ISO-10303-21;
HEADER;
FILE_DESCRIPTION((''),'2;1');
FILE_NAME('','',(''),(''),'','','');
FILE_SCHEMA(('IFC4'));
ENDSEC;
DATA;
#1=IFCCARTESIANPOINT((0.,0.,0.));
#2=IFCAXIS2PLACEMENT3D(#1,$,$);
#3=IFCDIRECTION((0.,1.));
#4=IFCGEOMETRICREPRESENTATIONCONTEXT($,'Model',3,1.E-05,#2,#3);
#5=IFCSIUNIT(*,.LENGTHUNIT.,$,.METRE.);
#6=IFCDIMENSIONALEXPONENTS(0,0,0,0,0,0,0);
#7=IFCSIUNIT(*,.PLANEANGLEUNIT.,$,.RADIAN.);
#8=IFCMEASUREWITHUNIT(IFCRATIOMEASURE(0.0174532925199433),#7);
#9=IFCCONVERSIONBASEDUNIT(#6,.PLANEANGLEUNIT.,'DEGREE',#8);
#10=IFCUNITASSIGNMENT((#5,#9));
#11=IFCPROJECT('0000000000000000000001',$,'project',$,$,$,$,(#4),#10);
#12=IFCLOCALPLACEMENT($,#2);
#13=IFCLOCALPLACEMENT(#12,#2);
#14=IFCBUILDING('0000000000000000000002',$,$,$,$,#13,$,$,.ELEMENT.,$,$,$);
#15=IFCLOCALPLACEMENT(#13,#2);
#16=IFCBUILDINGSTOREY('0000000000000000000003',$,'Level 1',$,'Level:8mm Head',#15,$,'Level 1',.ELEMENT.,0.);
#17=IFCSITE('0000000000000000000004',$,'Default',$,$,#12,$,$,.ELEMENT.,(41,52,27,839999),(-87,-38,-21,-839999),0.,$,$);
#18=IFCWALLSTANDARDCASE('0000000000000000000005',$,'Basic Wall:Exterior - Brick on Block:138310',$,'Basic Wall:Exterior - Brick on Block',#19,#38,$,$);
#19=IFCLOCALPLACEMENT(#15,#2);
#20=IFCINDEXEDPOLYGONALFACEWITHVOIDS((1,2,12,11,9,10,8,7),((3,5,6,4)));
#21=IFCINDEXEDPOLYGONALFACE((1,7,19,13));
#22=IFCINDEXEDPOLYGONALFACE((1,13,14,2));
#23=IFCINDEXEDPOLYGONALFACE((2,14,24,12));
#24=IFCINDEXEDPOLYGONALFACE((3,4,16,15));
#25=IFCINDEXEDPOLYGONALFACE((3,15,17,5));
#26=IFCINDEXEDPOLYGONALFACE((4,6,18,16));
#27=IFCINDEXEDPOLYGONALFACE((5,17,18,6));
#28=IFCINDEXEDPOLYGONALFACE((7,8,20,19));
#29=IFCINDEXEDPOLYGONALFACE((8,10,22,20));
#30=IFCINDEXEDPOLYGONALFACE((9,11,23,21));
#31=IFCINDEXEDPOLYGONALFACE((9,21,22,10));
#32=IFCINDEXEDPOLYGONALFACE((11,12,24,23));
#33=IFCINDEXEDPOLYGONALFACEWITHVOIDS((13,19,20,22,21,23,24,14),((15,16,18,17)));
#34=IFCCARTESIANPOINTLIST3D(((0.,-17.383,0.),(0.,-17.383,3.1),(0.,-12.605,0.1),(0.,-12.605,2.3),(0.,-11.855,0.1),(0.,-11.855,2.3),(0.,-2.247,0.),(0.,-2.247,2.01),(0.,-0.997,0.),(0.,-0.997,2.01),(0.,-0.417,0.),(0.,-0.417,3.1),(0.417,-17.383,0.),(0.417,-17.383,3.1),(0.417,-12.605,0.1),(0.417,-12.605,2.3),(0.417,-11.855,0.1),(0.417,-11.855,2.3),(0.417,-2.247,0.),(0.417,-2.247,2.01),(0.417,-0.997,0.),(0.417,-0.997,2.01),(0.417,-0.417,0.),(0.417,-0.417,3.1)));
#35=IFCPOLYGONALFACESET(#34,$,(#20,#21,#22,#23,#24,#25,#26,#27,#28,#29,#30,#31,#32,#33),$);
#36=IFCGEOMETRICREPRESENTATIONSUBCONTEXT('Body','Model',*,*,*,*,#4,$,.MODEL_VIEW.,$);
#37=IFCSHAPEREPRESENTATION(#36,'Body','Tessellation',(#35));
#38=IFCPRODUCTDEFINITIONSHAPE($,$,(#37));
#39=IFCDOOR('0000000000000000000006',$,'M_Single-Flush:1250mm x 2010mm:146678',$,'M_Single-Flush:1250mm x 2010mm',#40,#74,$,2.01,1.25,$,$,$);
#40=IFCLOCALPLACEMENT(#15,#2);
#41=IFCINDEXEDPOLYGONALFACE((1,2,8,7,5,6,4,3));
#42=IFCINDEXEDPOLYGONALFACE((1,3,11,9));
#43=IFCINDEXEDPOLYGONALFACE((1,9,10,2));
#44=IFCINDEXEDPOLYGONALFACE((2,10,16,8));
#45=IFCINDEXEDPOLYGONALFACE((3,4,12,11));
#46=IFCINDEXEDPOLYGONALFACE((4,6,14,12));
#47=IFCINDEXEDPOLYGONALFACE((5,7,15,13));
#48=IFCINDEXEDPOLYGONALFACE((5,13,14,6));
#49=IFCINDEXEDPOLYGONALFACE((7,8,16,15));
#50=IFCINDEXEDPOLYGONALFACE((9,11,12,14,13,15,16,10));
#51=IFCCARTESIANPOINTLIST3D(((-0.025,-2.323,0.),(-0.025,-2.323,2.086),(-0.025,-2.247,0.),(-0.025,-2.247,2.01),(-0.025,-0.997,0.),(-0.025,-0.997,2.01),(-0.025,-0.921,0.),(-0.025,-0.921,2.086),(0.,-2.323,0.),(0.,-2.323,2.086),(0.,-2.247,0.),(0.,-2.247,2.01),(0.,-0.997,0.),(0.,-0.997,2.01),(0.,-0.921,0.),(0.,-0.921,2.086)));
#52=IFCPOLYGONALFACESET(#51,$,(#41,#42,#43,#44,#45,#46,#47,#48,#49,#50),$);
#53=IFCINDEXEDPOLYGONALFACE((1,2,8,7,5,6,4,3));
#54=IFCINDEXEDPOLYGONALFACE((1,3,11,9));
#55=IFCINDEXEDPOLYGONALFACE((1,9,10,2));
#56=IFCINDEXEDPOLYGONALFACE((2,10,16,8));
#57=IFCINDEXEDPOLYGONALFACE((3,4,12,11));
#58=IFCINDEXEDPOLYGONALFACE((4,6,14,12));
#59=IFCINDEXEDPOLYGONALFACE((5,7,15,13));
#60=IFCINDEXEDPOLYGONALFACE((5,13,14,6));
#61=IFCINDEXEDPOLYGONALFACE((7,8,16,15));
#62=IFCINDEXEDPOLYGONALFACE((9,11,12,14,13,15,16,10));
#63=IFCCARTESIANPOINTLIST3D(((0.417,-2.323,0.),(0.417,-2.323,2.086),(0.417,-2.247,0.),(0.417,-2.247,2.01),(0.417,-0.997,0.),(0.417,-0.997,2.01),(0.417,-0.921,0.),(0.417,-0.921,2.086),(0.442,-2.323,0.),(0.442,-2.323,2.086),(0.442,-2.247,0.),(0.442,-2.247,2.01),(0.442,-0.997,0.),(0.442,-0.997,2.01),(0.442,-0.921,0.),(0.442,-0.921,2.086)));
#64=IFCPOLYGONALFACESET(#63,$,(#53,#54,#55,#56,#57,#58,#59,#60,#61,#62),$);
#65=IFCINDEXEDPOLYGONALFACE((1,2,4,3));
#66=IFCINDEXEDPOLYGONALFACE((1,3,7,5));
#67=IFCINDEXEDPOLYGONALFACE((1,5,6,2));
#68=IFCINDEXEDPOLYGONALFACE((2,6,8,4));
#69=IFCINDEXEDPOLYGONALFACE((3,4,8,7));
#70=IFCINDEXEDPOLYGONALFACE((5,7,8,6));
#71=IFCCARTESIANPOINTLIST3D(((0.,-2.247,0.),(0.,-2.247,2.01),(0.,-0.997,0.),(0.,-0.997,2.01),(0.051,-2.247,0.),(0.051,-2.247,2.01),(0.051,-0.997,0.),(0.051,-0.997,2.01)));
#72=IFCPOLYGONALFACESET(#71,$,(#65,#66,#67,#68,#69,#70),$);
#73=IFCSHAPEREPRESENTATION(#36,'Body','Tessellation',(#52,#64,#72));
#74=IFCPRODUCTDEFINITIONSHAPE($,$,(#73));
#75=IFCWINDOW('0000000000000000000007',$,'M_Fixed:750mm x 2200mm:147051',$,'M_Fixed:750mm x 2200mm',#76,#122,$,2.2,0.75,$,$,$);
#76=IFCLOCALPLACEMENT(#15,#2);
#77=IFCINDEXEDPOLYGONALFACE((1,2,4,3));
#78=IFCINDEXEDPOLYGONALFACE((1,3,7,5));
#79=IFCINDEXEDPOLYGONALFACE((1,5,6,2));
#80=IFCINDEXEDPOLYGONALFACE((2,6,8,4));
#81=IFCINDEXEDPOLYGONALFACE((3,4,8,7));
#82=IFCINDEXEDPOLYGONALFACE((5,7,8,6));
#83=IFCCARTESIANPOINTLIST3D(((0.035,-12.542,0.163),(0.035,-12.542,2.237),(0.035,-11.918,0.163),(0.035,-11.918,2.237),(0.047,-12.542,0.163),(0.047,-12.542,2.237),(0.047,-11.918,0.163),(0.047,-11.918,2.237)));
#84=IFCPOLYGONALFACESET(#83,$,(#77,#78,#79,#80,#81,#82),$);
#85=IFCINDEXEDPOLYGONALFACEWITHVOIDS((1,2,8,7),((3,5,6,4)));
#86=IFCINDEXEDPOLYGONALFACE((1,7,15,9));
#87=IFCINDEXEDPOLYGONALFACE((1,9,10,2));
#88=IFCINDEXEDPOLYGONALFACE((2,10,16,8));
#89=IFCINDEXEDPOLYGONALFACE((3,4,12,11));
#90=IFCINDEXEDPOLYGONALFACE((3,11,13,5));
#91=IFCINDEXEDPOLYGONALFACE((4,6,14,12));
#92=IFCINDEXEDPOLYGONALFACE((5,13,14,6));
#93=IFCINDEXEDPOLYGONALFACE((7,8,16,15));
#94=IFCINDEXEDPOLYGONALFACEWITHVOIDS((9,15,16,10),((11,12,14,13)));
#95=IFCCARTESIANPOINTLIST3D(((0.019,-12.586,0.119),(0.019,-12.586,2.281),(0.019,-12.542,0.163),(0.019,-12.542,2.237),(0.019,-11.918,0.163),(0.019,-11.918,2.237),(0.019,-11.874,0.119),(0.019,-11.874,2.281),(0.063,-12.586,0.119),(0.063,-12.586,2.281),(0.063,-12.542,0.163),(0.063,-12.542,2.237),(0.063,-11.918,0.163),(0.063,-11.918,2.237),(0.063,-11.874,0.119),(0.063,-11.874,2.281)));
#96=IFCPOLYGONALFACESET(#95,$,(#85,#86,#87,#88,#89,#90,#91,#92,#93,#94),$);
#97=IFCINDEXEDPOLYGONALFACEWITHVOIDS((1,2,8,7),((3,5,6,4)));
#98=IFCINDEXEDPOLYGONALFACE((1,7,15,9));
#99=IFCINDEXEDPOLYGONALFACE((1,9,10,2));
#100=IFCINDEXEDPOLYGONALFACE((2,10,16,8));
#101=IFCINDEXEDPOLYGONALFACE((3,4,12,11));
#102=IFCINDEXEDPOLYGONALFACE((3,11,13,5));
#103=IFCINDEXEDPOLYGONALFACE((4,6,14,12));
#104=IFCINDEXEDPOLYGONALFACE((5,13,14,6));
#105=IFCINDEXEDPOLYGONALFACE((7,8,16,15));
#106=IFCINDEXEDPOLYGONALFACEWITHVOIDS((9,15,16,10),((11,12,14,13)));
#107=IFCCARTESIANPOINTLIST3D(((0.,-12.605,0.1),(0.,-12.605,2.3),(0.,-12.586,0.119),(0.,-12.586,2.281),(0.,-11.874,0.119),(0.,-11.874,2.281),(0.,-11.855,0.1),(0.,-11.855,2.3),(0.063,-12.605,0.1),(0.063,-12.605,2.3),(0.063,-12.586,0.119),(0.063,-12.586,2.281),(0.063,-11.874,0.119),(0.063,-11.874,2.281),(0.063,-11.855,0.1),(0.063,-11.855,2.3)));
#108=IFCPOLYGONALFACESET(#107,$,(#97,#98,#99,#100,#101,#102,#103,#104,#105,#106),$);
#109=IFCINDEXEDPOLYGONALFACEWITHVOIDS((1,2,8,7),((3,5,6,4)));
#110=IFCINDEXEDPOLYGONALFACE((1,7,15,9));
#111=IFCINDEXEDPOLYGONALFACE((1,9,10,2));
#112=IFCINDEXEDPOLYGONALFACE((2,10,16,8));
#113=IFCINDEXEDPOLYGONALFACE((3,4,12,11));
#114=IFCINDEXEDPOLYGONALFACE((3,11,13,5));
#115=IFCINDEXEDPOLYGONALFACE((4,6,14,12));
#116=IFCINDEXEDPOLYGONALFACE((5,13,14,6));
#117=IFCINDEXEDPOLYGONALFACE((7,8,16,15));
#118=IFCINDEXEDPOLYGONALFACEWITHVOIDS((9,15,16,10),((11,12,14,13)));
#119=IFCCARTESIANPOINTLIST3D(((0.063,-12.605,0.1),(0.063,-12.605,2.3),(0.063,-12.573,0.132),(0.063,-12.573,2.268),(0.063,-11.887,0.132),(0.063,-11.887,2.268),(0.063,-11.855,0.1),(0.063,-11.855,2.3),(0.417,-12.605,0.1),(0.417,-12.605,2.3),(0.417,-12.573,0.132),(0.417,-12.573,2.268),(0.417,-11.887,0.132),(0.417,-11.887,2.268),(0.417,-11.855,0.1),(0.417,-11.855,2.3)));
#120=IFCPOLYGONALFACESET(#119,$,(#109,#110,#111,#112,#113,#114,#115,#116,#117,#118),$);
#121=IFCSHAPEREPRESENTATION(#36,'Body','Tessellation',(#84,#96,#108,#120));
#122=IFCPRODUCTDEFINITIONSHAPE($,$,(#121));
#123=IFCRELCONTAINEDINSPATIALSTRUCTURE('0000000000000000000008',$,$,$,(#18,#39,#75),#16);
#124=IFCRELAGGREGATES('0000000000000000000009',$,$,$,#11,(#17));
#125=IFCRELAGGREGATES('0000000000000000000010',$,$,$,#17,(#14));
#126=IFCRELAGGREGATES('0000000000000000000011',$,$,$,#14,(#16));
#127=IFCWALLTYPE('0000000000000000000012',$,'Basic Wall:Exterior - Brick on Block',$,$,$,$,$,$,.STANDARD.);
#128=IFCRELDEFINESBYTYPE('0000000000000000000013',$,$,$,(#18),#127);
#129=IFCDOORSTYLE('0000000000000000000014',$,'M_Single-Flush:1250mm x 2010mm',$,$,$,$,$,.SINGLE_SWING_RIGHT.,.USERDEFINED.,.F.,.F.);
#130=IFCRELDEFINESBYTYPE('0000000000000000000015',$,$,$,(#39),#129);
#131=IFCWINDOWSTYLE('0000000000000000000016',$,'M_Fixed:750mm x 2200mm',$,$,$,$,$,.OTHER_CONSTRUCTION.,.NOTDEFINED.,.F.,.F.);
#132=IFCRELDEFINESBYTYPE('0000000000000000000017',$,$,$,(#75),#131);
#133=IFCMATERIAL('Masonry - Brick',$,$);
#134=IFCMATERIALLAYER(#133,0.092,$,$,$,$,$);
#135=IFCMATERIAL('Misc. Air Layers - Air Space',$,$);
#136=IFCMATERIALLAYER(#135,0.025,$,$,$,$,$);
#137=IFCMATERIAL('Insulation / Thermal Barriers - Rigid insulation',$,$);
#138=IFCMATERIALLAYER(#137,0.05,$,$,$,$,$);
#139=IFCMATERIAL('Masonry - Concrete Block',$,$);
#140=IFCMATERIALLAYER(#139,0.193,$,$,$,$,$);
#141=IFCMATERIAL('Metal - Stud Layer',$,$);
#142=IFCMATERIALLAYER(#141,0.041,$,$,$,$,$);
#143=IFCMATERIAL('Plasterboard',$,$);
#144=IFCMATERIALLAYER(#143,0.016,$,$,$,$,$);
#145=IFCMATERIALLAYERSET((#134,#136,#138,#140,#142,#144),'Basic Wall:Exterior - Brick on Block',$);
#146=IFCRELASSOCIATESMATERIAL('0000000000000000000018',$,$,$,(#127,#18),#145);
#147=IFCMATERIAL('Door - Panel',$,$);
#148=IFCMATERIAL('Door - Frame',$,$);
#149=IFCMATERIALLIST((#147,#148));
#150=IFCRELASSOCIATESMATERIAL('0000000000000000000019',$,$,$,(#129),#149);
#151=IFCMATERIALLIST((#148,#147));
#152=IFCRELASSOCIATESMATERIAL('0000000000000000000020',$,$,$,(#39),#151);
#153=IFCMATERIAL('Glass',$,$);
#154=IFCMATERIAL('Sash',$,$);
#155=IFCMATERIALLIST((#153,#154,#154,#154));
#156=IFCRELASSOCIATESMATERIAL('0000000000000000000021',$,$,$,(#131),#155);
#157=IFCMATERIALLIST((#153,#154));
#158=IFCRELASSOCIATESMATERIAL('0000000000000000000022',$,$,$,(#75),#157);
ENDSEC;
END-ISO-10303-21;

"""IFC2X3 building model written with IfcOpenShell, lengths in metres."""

from ifc_helpers import new_model, entity, si_unit, converted_unit, direction, frame, frame_2d, origin, origin_2d_with_axis, place, context, subcontext, project, spatial, polyline, rectangle, outline, extrude, source, transform, mapped, material, material_list, layer, layer_set, layer_usage, type_object, type_shapes, element, fill, save


model = new_model("IFC2X3")

# Units and contexts
model_context = context("Model", 3, precision=1e-05, world=origin(), true_north=direction((0.0, 1.0)))
body_context = subcontext(model_context, "Body", "Model", "MODEL_VIEW")
ifc_project = project(units=[si_unit("LENGTHUNIT", "METRE"), converted_unit("PLANEANGLEUNIT", "DEGREE", entity("IfcRatioMeasure", 0.0174532925199433), si_unit("PLANEANGLEUNIT", "RADIAN"), dimensions=[0, 0, 0, 0, 0, 0, 0])], contexts=[model_context])

# Site, building, storey
site_placement = place(None, origin())
site = spatial("IfcSite", under=ifc_project, at=site_placement, Name="Default", CompositionType="ELEMENT", RefLatitude=(41, 52, 27, 839999), RefLongitude=(-87, -38, -21, -839999), RefElevation=0.0)
building_placement = place(site_placement, origin())
building = spatial("IfcBuilding", under=site, at=building_placement, CompositionType="ELEMENT")
storey_placement = place(building_placement, origin())
storey = spatial("IfcBuildingStorey", under=building, at=storey_placement, Name="Level 1", ObjectType="Level:8mm Head", LongName="Level 1", CompositionType="ELEMENT", Elevation=0.0)

# Shared definitions
ifc_material_1 = material(Name="Masonry - Brick")
ifc_layer_1 = layer(ifc_material_1, 0.092)
ifc_material_2 = material(Name="Misc. Air Layers - Air Space")
ifc_layer_2 = layer(ifc_material_2, 0.025)
ifc_material_3 = material(Name="Insulation / Thermal Barriers - Rigid insulation")
ifc_layer_3 = layer(ifc_material_3, 0.05)
ifc_material_4 = material(Name="Masonry - Concrete Block")
ifc_layer_4 = layer(ifc_material_4, 0.193)
ifc_material_5 = material(Name="Metal - Stud Layer")
ifc_layer_5 = layer(ifc_material_5, 0.041)
ifc_material_6 = material(Name="Plasterboard")
ifc_layer_6 = layer(ifc_material_6, 0.016)
ifc_layer_set_1 = layer_set([ifc_layer_1, ifc_layer_2, ifc_layer_3, ifc_layer_4, ifc_layer_5, ifc_layer_6], Name="Basic Wall:Exterior - Brick on Block")
wall_type_1 = type_object("IfcWallType", Name="Basic Wall:Exterior - Brick on Block", PredefinedType="STANDARD", material=ifc_layer_set_1)
ifc_material_7 = material(Name="Glass")
ifc_material_8 = material(Name="Sash")
ifc_material_9 = material(Name="Door - Frame")
ifc_material_10 = material(Name="Door - Panel")

# Wall, openings, door, window
ifc_layer_usage_1 = layer_usage(ifc_layer_set_1, "AXIS2", "NEGATIVE", 0.2085)
wall_1_placement = place(storey_placement, frame((0.2085, -17.383, 0.0), z_axis=(0.0, 0.0, 1.0), x_axis=(0.0, 1.0, 0.0)))
wall_1 = element("IfcWallStandardCase", 1, at=wall_1_placement, inside=storey, type_object=wall_type_1, material=ifc_layer_usage_1, Name="Basic Wall:Exterior - Brick on Block:138310", ObjectType="Basic Wall:Exterior - Brick on Block", context=body_context, shape_type="SweptSolid", body=[
    extrude(rectangle(XDim=16.966, YDim=0.417, at=frame_2d((8.483, 0.0), x_axis=(-1.0, 0.0))), origin(), (0.0, 0.0, 1.0), 3.1),
])
opening_1_placement = place(wall_1_placement, frame((15.136, -0.2085, 0.0)))
opening_1 = element("IfcOpeningElement", 2, at=opening_1_placement, cuts=wall_1, ObjectType="Opening", context=body_context, shape_type="SweptSolid", body=[
    extrude(rectangle(XDim=1.25, YDim=2.01, at=frame_2d((1.005, 0.625), x_axis=(0.0, 1.0))), frame((0.0, 0.0, 0.0), z_axis=(0.0, 1.0, 0.0), x_axis=(0.0, 0.0, 1.0)), (0.0, 0.0, 1.0), 0.417),
])
opening_2_placement = place(wall_1_placement, frame((4.778, -0.2085, 0.1)))
opening_2 = element("IfcOpeningElement", 3, at=opening_2_placement, cuts=wall_1, ObjectType="Opening", context=body_context, shape_type="SweptSolid", body=[
    extrude(rectangle(XDim=2.2, YDim=0.75, at=frame_2d((1.1, 0.375), x_axis=(1.0, 0.0))), frame((0.0, 0.0, 0.0), z_axis=(0.0, 1.0, 0.0), x_axis=(0.0, 0.0, 1.0)), (0.0, 0.0, 1.0), 0.417),
])
ifc_material_list_1 = material_list([ifc_material_9, ifc_material_10])
ifc_material_list_2 = material_list([ifc_material_10, ifc_material_9])
door_style_1 = type_object("IfcDoorStyle", Name="M_Single-Flush:1250mm x 2010mm", ConstructionType="USERDEFINED", OperationType="SINGLE_SWING_RIGHT", ParameterTakesPrecedence=False, Sizeable=False, material=ifc_material_list_2)
shared_shape_1 = source(origin(), body_context, "Body", "SweptSolid", [
    extrude(outline(polyline([(-0.701, -1.062), (0.701, -1.062), (0.701, 1.024), (0.625, 1.024), (0.625, -0.986), (-0.625, -0.986), (-0.625, 1.024), (-0.701, 1.024), (-0.701, -1.062)])), frame((0.625, 0.417, 1.024), z_axis=(0.0, 1.0, 0.0), x_axis=(1.0, 0.0, 0.0)), (0.0, 0.0, 1.0), 0.025),
    extrude(outline(polyline([(-1.062, -0.701), (1.024, -0.701), (1.024, -0.625), (-0.986, -0.625), (-0.986, 0.625), (1.024, 0.625), (1.024, 0.701), (-1.062, 0.701), (-1.062, -0.701)])), frame((0.625, -0.025, 1.024), z_axis=(0.0, 1.0, 0.0), x_axis=(0.0, 0.0, -1.0)), (0.0, 0.0, 1.0), 0.025),
    extrude(rectangle(XDim=0.051, YDim=1.25, at=frame_2d((0.0, 0.0), x_axis=(1.0, 0.0))), frame((0.625, 0.3915, 0.0), z_axis=(0.0, 0.0, 1.0), x_axis=(0.0, 1.0, 0.0)), (0.0, 0.0, 1.0), 2.01),
])
type_shapes(door_style_1, [shared_shape_1])
door_1_placement = place(opening_1_placement, origin())
door_1 = element("IfcDoor", 4, at=door_1_placement, inside=storey, type_object=door_style_1, material=ifc_material_list_1, Name="M_Single-Flush:1250mm x 2010mm:146678", ObjectType="M_Single-Flush:1250mm x 2010mm", OverallHeight=2.01, OverallWidth=1.25, context=body_context, shape_type="MappedRepresentation", body=[
    mapped(shared_shape_1, transform((0.0, 0.0, 0.0), scale=1.0)),
])
fill(opening_1, door_1)
ifc_material_list_3 = material_list([ifc_material_7, ifc_material_8])
ifc_material_list_4 = material_list([ifc_material_7, ifc_material_8, ifc_material_8, ifc_material_8])
window_style_1 = type_object("IfcWindowStyle", Name="M_Fixed:750mm x 2200mm", ConstructionType="OTHER_CONSTRUCTION", OperationType="NOTDEFINED", ParameterTakesPrecedence=False, Sizeable=False, material=ifc_material_list_4)
shared_shape_2 = source(origin(), body_context, "Body", "SweptSolid", [
    extrude(rectangle(XDim=0.012, YDim=0.624, at=origin_2d_with_axis()), frame((0.375, 0.376, 0.063), z_axis=(0.0, 0.0, 1.0), x_axis=(0.0, -1.0, 0.0)), (0.0, 0.0, 1.0), 2.074),
    extrude(outline(polyline([(-0.356, -1.081), (0.356, -1.081), (0.356, 1.081), (-0.356, 1.081), (-0.356, -1.081)]), holes=[polyline([(-0.312, -1.037), (-0.312, 1.037), (0.312, 1.037), (0.312, -1.037), (-0.312, -1.037)])]), frame((0.375, 0.354, 1.1), z_axis=(0.0, 1.0, 0.0), x_axis=(1.0, 0.0, 0.0)), (0.0, 0.0, 1.0), 0.044),
    extrude(outline(polyline([(-0.375, -1.1), (0.375, -1.1), (0.375, 1.1), (-0.375, 1.1), (-0.375, -1.1)]), holes=[polyline([(-0.356, -1.081), (-0.356, 1.081), (0.356, 1.081), (0.356, -1.081), (-0.356, -1.081)])]), frame((0.375, 0.354, 1.1), z_axis=(0.0, 1.0, 0.0), x_axis=(1.0, 0.0, 0.0)), (0.0, 0.0, 1.0), 0.063),
    extrude(outline(polyline([(-0.375, -1.1), (0.375, -1.1), (0.375, 1.1), (-0.375, 1.1), (-0.375, -1.1)]), holes=[polyline([(-0.343, -1.068), (-0.343, 1.068), (0.343, 1.068), (0.343, -1.068), (-0.343, -1.068)])]), frame((0.375, 0.0, 1.1), z_axis=(0.0, 1.0, 0.0), x_axis=(1.0, 0.0, 0.0)), (0.0, 0.0, 1.0), 0.354),
])
type_shapes(window_style_1, [shared_shape_2])
window_1_placement = place(opening_2_placement, origin())
window_1 = element("IfcWindow", 5, at=window_1_placement, inside=storey, type_object=window_style_1, material=ifc_material_list_3, Name="M_Fixed:750mm x 2200mm:147051", ObjectType="M_Fixed:750mm x 2200mm", OverallHeight=2.2, OverallWidth=0.75, context=body_context, shape_type="MappedRepresentation", body=[
    mapped(shared_shape_2, transform((0.0, 0.0, 0.0), scale=1.0)),
])
fill(opening_2, window_1)

save(model, "model.ifc")
